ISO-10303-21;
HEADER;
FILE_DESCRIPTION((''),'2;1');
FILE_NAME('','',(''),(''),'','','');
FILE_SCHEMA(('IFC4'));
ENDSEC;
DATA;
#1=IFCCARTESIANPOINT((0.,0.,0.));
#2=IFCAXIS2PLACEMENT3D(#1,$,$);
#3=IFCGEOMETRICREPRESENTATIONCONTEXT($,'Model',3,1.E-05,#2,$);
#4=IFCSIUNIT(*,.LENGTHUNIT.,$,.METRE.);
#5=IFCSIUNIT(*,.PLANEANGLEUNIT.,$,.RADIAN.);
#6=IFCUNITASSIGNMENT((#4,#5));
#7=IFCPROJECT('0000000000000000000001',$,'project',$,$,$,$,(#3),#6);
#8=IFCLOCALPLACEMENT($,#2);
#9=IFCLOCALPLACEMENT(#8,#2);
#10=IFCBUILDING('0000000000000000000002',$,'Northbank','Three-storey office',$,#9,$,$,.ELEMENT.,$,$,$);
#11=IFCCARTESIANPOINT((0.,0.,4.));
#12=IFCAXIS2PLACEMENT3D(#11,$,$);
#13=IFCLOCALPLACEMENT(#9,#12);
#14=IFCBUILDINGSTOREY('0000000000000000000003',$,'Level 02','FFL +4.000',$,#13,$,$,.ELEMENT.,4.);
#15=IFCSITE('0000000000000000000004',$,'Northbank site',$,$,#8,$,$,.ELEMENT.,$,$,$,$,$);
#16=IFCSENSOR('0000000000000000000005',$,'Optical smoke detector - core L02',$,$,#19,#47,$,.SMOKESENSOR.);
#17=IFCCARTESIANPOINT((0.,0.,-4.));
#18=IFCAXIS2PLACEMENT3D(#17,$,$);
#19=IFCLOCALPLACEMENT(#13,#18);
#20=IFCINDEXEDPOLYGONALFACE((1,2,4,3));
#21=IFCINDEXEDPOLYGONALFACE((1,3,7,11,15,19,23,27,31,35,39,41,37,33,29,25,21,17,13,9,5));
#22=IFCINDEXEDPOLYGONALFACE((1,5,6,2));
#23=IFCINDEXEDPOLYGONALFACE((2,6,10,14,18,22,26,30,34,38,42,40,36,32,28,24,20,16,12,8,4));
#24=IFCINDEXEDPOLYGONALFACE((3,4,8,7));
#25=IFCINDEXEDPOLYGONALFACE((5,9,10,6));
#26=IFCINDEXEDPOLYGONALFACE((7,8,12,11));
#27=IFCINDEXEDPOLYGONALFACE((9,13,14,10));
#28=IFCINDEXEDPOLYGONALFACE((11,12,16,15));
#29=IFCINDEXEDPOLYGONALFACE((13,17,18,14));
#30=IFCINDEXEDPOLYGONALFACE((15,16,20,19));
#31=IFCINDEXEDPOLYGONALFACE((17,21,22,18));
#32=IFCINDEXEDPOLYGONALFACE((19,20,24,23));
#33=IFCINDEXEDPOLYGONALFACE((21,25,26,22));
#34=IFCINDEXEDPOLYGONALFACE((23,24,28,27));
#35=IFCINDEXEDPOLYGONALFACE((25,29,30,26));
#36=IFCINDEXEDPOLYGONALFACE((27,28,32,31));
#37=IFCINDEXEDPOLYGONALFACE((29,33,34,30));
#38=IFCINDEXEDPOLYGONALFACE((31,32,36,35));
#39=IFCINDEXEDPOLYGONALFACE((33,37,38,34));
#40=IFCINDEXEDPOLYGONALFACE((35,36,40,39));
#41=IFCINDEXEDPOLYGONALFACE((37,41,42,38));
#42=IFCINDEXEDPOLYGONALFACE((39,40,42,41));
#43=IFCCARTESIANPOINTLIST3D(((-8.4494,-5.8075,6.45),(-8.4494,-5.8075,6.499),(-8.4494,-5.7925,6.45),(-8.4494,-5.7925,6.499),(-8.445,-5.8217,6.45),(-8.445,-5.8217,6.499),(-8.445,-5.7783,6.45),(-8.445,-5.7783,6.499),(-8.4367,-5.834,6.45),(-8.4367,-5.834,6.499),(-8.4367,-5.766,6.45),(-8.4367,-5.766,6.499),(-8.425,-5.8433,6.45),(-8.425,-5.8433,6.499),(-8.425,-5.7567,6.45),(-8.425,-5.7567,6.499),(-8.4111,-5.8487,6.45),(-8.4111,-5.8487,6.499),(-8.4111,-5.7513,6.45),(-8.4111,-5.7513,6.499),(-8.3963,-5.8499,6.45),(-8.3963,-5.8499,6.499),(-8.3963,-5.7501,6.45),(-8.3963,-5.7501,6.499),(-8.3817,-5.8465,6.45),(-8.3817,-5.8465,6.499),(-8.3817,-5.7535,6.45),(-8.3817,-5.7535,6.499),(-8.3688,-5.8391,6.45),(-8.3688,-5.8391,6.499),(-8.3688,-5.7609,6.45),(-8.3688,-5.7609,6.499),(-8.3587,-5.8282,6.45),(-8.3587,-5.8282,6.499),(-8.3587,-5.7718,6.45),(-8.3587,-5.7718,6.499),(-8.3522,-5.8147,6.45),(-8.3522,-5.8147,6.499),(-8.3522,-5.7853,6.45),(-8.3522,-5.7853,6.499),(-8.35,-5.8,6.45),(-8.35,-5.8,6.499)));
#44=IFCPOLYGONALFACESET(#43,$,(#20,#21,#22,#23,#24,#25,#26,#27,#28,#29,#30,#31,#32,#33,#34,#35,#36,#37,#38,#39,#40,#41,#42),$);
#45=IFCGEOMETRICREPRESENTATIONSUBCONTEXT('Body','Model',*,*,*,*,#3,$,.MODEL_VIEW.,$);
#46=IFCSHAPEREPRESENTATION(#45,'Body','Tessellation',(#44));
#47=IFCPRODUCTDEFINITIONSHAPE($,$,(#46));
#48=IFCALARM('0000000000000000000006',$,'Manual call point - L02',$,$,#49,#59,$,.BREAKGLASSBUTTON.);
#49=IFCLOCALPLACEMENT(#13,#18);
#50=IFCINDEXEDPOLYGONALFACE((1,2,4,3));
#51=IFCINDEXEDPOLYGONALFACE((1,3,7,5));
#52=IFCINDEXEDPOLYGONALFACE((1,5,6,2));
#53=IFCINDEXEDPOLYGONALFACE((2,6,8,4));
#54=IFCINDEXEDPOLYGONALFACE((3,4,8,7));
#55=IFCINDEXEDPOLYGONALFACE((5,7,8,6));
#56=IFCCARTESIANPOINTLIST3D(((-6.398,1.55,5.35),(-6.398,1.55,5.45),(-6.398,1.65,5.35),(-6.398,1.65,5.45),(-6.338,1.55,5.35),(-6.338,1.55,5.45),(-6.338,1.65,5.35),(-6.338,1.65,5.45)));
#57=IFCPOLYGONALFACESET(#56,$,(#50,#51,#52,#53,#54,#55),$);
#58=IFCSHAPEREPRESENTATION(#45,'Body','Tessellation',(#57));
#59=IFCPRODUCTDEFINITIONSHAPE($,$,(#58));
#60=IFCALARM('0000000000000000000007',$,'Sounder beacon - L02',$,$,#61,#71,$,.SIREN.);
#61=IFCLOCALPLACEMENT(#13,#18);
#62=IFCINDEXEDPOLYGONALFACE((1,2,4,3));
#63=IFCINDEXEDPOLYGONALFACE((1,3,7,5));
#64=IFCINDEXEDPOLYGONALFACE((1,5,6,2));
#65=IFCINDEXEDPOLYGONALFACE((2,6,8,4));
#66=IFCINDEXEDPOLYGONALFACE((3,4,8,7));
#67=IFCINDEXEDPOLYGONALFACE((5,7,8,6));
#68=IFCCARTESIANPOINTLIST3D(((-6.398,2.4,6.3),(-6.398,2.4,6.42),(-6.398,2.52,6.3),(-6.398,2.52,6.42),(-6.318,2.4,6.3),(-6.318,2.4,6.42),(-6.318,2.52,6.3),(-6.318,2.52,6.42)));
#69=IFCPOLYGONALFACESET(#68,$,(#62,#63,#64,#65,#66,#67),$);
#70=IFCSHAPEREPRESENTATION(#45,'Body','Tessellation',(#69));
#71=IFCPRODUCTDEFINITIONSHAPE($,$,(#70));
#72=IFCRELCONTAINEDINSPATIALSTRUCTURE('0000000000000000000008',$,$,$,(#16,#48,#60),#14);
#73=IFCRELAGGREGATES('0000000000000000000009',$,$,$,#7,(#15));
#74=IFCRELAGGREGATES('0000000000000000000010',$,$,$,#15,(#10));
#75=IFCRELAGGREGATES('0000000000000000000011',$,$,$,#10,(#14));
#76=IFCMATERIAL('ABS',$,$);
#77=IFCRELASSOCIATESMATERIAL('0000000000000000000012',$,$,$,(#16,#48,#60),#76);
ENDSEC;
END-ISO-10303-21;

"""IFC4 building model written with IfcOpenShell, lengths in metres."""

from ifc_helpers import new_model, si_unit, frame, origin, place, context, subcontext, project, spatial, rectangle, circle, extrude, material, element, save


model = new_model("IFC4")

# Units and contexts
model_context = context("Model", 3, precision=1e-05, world=origin())
body_context = subcontext(model_context, "Body", "Model", "MODEL_VIEW")
ifc_project = project(units=[si_unit("LENGTHUNIT", "METRE"), si_unit("PLANEANGLEUNIT", "RADIAN")], contexts=[model_context])

# Site, building, storey
site_placement = place(None, origin())
site = spatial("IfcSite", under=ifc_project, at=site_placement, Name="Northbank site", CompositionType="ELEMENT")
building_placement = place(site_placement, origin())
building = spatial("IfcBuilding", under=site, at=building_placement, Name="Northbank", Description="Three-storey office", CompositionType="ELEMENT")
storey_placement = place(building_placement, frame((0.0, 0.0, 4.0)))
storey = spatial("IfcBuildingStorey", under=building, at=storey_placement, Name="Level 02", Description="FFL +4.000", CompositionType="ELEMENT", Elevation=4.0)

# Sensor
ifc_material_1 = material(Name="ABS")
sensor_1_placement = place(storey_placement, frame((0.0, 0.0, -4.0)))
element("IfcSensor", 1, at=sensor_1_placement, inside=storey, material=ifc_material_1, Name="Optical smoke detector - core L02", PredefinedType="SMOKESENSOR", context=body_context, shape_type="SweptSolid", body=[
    extrude(circle(Radius=0.05), frame((-8.4, -5.8, 6.45), z_axis=(0.0, 0.0, 1.0), x_axis=(1.0, 0.0, 0.0)), (0.0, 0.0, 1.0), 0.049),
])

# Alarms
alarm_1_placement = place(storey_placement, frame((0.0, 0.0, -4.0)))
element("IfcAlarm", 2, at=alarm_1_placement, inside=storey, material=ifc_material_1, Name="Manual call point - L02", PredefinedType="BREAKGLASSBUTTON", context=body_context, shape_type="SweptSolid", body=[
    extrude(rectangle(XDim=0.06, YDim=0.1), frame((-6.368, 1.6, 5.35)), (0.0, 0.0, 1.0), 0.1),
])
alarm_2_placement = place(storey_placement, frame((0.0, 0.0, -4.0)))
element("IfcAlarm", 3, at=alarm_2_placement, inside=storey, material=ifc_material_1, Name="Sounder beacon - L02", PredefinedType="SIREN", context=body_context, shape_type="SweptSolid", body=[
    extrude(rectangle(XDim=0.08, YDim=0.12), frame((-6.358, 2.46, 6.3)), (0.0, 0.0, 1.0), 0.12),
])

save(model, "model.ifc")
